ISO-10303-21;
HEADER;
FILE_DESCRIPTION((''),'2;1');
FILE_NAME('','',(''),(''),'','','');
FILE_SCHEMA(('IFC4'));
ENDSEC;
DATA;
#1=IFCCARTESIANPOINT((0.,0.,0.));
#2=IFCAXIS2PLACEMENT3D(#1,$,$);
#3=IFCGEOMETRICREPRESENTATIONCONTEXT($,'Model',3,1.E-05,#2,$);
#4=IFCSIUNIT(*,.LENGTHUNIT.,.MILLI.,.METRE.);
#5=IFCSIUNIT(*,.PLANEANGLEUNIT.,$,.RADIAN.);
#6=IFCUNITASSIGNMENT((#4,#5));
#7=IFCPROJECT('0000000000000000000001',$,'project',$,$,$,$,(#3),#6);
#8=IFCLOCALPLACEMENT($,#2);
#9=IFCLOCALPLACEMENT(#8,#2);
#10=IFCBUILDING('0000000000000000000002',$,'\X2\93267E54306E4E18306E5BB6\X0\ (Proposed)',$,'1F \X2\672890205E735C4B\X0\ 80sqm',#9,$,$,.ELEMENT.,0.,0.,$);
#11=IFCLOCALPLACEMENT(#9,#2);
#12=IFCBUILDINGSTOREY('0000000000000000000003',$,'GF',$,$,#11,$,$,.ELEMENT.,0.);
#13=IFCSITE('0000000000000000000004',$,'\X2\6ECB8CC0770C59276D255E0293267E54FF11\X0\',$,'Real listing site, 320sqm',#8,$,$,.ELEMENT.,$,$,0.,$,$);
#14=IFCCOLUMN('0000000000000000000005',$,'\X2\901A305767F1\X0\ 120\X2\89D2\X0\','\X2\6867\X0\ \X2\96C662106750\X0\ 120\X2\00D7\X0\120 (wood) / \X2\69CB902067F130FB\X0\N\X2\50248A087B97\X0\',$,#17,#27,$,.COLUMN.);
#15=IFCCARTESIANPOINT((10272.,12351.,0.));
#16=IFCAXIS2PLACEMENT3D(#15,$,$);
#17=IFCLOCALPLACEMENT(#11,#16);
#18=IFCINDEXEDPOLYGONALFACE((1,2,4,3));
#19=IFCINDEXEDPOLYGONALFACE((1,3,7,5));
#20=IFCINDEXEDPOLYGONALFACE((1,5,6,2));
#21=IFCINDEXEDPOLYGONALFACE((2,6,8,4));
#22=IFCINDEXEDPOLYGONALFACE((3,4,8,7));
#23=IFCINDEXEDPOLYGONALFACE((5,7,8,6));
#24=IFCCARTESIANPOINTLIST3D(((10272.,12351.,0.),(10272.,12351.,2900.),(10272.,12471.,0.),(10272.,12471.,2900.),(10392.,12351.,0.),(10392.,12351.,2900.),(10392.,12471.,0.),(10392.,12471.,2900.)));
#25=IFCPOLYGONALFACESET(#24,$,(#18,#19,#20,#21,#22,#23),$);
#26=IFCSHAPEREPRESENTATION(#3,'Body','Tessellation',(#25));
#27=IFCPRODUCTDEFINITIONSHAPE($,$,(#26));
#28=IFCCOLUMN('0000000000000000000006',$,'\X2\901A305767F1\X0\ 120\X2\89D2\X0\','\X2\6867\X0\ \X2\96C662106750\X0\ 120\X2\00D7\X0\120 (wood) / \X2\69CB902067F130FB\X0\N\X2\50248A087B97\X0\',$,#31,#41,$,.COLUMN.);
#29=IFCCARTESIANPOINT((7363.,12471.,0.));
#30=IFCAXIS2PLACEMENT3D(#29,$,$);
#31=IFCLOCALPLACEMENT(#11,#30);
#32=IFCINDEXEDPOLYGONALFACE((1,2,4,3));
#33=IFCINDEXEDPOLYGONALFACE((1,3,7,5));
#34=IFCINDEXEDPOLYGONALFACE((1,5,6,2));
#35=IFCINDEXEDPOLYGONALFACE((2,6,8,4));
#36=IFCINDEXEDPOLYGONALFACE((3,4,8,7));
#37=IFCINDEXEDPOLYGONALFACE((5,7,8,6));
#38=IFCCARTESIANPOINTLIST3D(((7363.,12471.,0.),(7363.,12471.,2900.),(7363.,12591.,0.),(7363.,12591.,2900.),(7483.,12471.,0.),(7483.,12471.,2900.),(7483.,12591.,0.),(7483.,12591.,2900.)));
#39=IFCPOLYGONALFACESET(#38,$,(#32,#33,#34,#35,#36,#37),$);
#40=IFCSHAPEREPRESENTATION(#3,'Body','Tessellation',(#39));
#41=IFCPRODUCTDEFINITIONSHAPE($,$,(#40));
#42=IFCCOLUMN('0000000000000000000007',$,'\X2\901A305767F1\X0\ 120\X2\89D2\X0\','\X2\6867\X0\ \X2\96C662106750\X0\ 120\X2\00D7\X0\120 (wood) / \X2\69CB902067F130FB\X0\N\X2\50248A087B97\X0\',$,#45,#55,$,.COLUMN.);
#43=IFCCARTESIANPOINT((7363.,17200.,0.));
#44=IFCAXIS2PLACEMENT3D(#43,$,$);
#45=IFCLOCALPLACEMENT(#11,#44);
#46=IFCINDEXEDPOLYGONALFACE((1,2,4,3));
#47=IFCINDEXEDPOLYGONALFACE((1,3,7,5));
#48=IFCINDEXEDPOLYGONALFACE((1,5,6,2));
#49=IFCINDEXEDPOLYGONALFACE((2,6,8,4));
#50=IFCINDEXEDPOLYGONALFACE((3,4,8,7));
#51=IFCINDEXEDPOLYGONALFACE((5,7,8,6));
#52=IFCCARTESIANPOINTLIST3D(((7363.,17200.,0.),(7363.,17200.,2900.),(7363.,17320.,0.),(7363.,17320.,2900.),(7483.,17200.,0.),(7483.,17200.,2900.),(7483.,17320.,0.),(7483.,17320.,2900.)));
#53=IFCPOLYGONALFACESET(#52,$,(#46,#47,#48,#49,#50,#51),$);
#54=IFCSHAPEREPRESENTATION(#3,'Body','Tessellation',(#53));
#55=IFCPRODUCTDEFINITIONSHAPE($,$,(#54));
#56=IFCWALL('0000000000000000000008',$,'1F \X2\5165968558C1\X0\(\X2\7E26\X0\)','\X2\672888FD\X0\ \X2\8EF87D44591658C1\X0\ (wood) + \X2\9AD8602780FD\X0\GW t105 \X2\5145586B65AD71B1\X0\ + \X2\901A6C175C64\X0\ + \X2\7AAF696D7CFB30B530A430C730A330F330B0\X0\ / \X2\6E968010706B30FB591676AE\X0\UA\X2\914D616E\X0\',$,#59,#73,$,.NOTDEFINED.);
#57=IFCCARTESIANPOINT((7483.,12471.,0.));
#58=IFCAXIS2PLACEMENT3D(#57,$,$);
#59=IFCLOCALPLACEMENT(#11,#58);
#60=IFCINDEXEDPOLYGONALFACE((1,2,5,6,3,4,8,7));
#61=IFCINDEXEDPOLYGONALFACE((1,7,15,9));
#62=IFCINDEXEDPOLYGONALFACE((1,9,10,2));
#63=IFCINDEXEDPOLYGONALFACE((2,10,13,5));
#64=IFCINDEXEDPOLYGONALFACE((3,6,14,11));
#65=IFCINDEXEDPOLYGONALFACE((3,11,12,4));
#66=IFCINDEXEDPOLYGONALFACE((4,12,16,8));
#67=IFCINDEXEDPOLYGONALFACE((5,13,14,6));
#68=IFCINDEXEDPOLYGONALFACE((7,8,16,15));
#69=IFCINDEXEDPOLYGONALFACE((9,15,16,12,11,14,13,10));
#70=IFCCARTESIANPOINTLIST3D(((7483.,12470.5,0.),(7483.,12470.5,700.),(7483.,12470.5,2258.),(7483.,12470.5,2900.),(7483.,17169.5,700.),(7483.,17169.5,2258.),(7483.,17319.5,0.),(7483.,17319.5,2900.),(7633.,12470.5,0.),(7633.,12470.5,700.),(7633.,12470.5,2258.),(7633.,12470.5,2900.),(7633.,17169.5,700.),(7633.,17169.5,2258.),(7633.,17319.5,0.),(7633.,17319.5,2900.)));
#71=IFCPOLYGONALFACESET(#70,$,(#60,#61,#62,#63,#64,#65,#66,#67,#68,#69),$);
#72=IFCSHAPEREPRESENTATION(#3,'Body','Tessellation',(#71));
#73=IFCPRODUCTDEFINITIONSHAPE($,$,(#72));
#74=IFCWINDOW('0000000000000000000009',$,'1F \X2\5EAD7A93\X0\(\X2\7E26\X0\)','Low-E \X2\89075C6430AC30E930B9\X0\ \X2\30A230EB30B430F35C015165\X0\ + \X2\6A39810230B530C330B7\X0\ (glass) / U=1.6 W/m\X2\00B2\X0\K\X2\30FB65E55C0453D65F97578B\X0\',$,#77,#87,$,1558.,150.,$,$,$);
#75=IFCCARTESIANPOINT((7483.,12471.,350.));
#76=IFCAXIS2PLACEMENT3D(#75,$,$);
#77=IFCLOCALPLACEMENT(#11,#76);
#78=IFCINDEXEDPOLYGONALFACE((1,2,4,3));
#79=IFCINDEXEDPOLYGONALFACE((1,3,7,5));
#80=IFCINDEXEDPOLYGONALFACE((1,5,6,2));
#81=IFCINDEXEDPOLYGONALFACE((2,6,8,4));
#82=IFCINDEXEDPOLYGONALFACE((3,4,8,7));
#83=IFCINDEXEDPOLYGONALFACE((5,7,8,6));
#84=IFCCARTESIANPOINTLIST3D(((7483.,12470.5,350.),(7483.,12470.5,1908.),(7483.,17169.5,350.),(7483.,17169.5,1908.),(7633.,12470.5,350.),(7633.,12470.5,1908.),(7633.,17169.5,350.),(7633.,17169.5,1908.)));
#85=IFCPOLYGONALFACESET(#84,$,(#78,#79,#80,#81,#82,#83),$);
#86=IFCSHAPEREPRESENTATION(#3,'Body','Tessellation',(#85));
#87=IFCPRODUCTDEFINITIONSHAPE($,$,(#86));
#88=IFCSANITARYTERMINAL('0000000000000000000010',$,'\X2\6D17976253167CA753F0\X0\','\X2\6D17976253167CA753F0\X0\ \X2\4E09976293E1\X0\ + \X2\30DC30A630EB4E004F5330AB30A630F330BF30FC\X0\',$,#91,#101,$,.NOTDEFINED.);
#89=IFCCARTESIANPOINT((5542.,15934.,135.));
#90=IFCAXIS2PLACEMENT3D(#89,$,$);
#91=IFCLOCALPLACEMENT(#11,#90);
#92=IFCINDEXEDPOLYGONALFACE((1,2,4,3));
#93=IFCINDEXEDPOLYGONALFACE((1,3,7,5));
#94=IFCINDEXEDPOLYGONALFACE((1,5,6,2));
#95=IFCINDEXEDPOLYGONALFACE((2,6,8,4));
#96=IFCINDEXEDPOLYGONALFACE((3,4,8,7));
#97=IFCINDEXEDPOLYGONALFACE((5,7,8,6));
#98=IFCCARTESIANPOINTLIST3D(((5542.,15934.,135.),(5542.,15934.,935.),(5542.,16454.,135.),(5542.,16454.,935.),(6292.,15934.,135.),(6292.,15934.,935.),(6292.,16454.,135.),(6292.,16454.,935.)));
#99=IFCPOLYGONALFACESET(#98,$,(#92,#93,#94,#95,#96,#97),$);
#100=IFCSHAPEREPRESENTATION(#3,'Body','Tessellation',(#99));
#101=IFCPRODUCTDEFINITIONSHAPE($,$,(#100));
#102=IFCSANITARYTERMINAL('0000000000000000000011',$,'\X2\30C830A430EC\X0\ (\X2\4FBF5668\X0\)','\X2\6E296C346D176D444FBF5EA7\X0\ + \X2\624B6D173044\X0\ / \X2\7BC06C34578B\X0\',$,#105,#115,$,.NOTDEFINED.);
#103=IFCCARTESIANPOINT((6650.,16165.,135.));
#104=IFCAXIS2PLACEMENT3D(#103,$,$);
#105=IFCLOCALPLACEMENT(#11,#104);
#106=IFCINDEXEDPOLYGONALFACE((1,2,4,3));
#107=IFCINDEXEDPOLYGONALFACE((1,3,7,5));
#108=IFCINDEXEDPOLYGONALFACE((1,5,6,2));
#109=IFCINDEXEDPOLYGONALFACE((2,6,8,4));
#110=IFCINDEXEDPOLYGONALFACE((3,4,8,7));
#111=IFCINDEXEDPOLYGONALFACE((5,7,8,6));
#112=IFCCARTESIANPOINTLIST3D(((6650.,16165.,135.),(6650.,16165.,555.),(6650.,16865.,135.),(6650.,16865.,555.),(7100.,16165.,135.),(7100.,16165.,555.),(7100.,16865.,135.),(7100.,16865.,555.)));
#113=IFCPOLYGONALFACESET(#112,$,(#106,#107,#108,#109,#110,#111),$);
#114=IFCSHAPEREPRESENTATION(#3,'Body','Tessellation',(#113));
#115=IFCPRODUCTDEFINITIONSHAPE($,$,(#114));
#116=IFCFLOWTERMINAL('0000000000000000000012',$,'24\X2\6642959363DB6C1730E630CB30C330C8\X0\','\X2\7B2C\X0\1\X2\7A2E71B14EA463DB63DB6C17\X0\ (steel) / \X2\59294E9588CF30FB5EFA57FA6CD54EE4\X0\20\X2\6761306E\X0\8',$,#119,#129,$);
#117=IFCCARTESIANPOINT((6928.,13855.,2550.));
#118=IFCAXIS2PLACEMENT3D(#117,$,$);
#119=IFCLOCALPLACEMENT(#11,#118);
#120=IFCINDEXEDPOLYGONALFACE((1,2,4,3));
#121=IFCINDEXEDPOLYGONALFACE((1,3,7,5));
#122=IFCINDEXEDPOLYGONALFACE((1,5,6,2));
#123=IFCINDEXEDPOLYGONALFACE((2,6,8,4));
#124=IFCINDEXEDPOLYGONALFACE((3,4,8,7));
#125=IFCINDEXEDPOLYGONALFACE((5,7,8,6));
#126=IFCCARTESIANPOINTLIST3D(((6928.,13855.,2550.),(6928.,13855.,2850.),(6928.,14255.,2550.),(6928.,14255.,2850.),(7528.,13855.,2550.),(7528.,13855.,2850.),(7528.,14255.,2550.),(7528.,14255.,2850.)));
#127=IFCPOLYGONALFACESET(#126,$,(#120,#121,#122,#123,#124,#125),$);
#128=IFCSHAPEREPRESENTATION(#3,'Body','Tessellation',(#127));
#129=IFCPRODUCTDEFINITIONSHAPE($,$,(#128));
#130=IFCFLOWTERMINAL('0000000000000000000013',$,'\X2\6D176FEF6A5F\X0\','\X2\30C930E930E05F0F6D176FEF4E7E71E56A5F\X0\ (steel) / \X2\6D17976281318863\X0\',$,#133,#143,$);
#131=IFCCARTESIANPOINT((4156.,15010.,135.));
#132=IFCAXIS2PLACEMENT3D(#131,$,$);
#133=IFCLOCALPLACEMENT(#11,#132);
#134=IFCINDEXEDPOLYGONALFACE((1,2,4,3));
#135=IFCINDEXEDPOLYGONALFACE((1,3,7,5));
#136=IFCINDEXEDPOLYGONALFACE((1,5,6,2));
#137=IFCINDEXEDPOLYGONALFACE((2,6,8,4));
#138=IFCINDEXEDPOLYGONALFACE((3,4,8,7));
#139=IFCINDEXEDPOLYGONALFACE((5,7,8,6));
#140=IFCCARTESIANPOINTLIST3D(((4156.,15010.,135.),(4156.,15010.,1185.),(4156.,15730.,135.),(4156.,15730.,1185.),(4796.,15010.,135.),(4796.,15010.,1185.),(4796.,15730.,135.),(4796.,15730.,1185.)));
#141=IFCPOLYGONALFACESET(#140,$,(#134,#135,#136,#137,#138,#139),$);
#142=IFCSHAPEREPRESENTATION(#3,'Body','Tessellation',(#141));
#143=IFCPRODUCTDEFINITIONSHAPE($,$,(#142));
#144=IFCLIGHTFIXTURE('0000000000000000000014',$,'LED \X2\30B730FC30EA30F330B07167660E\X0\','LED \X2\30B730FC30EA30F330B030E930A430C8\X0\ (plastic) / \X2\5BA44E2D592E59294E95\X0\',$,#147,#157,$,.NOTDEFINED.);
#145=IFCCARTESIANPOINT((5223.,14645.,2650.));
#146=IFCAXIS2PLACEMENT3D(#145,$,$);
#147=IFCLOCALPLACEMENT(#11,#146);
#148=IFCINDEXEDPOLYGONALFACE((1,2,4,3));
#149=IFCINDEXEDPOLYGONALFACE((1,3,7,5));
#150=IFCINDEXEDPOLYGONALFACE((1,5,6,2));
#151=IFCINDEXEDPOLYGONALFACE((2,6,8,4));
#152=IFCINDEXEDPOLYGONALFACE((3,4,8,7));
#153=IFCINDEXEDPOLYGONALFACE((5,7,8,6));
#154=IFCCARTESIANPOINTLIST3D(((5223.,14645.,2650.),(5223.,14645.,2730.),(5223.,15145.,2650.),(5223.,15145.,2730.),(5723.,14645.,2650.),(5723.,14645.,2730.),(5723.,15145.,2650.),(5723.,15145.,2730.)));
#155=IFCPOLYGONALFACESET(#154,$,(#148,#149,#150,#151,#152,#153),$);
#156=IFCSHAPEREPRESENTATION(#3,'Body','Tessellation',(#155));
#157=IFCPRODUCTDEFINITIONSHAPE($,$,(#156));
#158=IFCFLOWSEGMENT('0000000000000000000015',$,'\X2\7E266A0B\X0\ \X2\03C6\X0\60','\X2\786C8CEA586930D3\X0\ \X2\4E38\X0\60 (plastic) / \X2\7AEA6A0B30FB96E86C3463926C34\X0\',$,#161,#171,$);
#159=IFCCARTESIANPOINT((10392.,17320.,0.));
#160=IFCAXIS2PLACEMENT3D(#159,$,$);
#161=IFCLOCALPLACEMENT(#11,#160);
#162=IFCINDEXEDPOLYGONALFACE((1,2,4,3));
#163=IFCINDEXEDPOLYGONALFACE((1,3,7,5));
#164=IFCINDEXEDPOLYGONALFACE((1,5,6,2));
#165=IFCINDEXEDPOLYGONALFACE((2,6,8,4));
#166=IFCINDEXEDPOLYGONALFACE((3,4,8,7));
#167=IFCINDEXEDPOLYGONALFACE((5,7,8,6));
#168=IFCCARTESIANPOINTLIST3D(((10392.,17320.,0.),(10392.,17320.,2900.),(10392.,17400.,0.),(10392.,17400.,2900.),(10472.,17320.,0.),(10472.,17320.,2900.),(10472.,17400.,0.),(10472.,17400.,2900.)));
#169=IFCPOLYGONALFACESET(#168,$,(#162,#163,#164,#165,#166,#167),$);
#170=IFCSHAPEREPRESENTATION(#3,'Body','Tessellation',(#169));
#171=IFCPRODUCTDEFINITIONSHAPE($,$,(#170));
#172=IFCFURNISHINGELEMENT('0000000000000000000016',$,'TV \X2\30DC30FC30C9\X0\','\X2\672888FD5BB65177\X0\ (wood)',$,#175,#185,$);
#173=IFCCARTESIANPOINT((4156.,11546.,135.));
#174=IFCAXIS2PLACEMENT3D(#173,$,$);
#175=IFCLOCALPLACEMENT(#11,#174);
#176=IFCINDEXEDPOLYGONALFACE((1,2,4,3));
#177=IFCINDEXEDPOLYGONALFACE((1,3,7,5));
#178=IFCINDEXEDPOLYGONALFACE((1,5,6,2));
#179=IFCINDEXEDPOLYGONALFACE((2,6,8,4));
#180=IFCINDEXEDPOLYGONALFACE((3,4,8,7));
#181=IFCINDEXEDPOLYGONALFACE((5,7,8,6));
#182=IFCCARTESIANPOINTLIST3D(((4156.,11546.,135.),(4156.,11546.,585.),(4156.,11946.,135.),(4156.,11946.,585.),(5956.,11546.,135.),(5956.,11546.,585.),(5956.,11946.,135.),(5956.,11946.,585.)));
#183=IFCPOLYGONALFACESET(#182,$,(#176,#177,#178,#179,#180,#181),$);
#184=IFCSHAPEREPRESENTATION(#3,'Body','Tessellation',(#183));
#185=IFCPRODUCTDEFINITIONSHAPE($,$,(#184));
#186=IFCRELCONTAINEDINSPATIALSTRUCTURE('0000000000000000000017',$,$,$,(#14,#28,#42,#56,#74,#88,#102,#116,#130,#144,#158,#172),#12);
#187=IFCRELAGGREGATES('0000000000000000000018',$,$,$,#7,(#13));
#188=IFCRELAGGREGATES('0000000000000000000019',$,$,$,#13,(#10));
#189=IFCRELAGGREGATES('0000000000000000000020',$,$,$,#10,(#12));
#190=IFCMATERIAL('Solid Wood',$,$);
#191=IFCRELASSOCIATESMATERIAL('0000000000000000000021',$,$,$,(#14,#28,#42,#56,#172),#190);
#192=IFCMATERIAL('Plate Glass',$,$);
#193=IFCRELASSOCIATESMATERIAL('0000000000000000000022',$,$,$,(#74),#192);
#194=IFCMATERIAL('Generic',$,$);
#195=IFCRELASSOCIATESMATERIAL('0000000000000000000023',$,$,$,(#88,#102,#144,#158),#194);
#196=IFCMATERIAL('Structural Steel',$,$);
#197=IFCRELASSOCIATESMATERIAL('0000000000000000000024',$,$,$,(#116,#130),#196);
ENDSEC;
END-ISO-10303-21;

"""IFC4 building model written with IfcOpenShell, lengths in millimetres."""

from ifc_helpers import new_model, si_unit, frame, frame_2d, origin, place, context, project, spatial, rectangle, extrude, material, element, fill, save


model = new_model("IFC4")

# Units and contexts
model_context = context("Model", 3, precision=1e-05, world=origin())
ifc_project = project(units=[si_unit("LENGTHUNIT", "METRE", prefix="MILLI"), si_unit("PLANEANGLEUNIT", "RADIAN")], contexts=[model_context])

# Site, building, storey
site_placement = place(None, origin())
site = spatial("IfcSite", under=ifc_project, at=site_placement, Name="滋賀県大津市錦織１", ObjectType="Real listing site, 320sqm", CompositionType="ELEMENT", RefElevation=0.0)
building_placement = place(site_placement, origin())
building = spatial("IfcBuilding", under=site, at=building_placement, Name="錦織の丘の家 (Proposed)", ObjectType="1F 木造平屋 80sqm", CompositionType="ELEMENT", ElevationOfRefHeight=0.0, ElevationOfTerrain=0.0)
storey_placement = place(building_placement, origin())
storey = spatial("IfcBuildingStorey", under=building, at=storey_placement, Name="GF", CompositionType="ELEMENT", Elevation=0.0)

# Columns
ifc_material_1 = material(Name="Solid Wood")
column_1_placement = place(storey_placement, frame((10272.0, 12351.0, 0.0)))
element("IfcColumn", 1, at=column_1_placement, inside=storey, material=ifc_material_1, Name="通し柱 120角", Description="桧 集成材 120×120 (wood) / 構造柱・N値計算", PredefinedType="COLUMN", context=model_context, shape_type="SweptSolid", body=[
    extrude(rectangle(XDim=120.0, YDim=120.0, at=frame_2d((60.0, 60.0))), frame((10272.0, 12351.0, 0.0)), (0.0, 0.0, 1.0), 2900.0),
])
column_2_placement = place(storey_placement, frame((7363.0, 12471.0, 0.0)))
element("IfcColumn", 2, at=column_2_placement, inside=storey, material=ifc_material_1, Name="通し柱 120角", Description="桧 集成材 120×120 (wood) / 構造柱・N値計算", PredefinedType="COLUMN", context=model_context, shape_type="SweptSolid", body=[
    extrude(rectangle(XDim=120.0, YDim=120.0, at=frame_2d((60.0, 60.0))), frame((7363.0, 12471.0, 0.0)), (0.0, 0.0, 1.0), 2900.0),
])
column_3_placement = place(storey_placement, frame((7363.0, 17200.0, 0.0)))
element("IfcColumn", 3, at=column_3_placement, inside=storey, material=ifc_material_1, Name="通し柱 120角", Description="桧 集成材 120×120 (wood) / 構造柱・N値計算", PredefinedType="COLUMN", context=model_context, shape_type="SweptSolid", body=[
    extrude(rectangle(XDim=120.0, YDim=120.0, at=frame_2d((60.0, 60.0))), frame((7363.0, 17200.0, 0.0)), (0.0, 0.0, 1.0), 2900.0),
])

# Wall, opening, window
wall_1_placement = place(storey_placement, frame((7483.0, 12471.0, 0.0)))
wall_1 = element("IfcWall", 4, at=wall_1_placement, inside=storey, material=ifc_material_1, Name="1F 入隅壁(縦)", Description="木製 軸組外壁 (wood) + 高性能GW t105 充填断熱 + 通気層 + 窯業系サイディング / 準耐火・外皮UA配慮", PredefinedType="NOTDEFINED", context=model_context, shape_type="SweptSolid", body=[
    extrude(rectangle(XDim=150.0, YDim=4849.0, at=frame_2d((75.0, 2424.0))), frame((7483.0, 12471.0, 0.0)), (0.0, 0.0, 1.0), 2900.0),
])
opening_placement = place(storey_placement, frame((7483.0, 12471.0, 350.0)))
opening = element("IfcOpeningElement", 5, at=opening_placement, cuts=wall_1, PredefinedType="NOTDEFINED", context=model_context, shape_type="SweptSolid", body=[
    extrude(rectangle(XDim=150.0, YDim=4699.0, at=frame_2d((75.0, 2349.0))), frame((7483.0, 12471.0, 350.0)), (0.0, 0.0, 1.0), 1558.0),
])
ifc_material_2 = material(Name="Plate Glass")
window_placement = place(storey_placement, frame((7483.0, 12471.0, 350.0)))
window = element("IfcWindow", 6, at=window_placement, inside=storey, material=ifc_material_2, Name="1F 庭窓(縦)", Description="Low-E 複層ガラス アルゴン封入 + 樹脂サッシ (glass) / U=1.6 W/m²K・日射取得型", OverallHeight=1558.0, OverallWidth=150.0, context=model_context, shape_type="SweptSolid", body=[
    extrude(rectangle(XDim=150.0, YDim=4699.0, at=frame_2d((75.0, 2349.0))), frame((7483.0, 12471.0, 350.0)), (0.0, 0.0, 1.0), 1558.0),
])
fill(opening, window)

# Sanitary terminals
ifc_material_3 = material(Name="Generic")
sanitary_terminal_1_placement = place(storey_placement, frame((5542.0, 15934.0, 135.0)))
element("IfcSanitaryTerminal", 7, at=sanitary_terminal_1_placement, inside=storey, material=ifc_material_3, Name="洗面化粧台", Description="洗面化粧台 三面鏡 + ボウル一体カウンター", PredefinedType="NOTDEFINED", context=model_context, shape_type="SweptSolid", body=[
    extrude(rectangle(XDim=750.0, YDim=520.0, at=frame_2d((375.0, 260.0))), frame((5542.0, 15934.0, 135.0)), (0.0, 0.0, 1.0), 800.0),
])
sanitary_terminal_2_placement = place(storey_placement, frame((6650.0, 16165.0, 135.0)))
element("IfcSanitaryTerminal", 8, at=sanitary_terminal_2_placement, inside=storey, material=ifc_material_3, Name="トイレ (便器)", Description="温水洗浄便座 + 手洗い / 節水型", PredefinedType="NOTDEFINED", context=model_context, shape_type="SweptSolid", body=[
    extrude(rectangle(XDim=450.0, YDim=700.0, at=frame_2d((225.0, 350.0))), frame((6650.0, 16165.0, 135.0)), (0.0, 0.0, 1.0), 420.0),
])

# Flow terminals
ifc_material_4 = material(Name="Structural Steel")
flow_terminal_1_placement = place(storey_placement, frame((6928.0, 13855.0, 2550.0)))
element("IfcFlowTerminal", 9, at=flow_terminal_1_placement, inside=storey, material=ifc_material_4, Name="24時間換気ユニット", Description="第1種熱交換換気 (steel) / 天井裏・建基法令20条の8", context=model_context, shape_type="SweptSolid", body=[
    extrude(rectangle(XDim=600.0, YDim=400.0, at=frame_2d((300.0, 200.0))), frame((6928.0, 13855.0, 2550.0)), (0.0, 0.0, 1.0), 300.0),
])
flow_terminal_2_placement = place(storey_placement, frame((4156.0, 15010.0, 135.0)))
element("IfcFlowTerminal", 10, at=flow_terminal_2_placement, inside=storey, material=ifc_material_4, Name="洗濯機", Description="ドラム式洗濯乾燥機 (steel) / 洗面脱衣", context=model_context, shape_type="SweptSolid", body=[
    extrude(rectangle(XDim=640.0, YDim=720.0, at=frame_2d((320.0, 360.0))), frame((4156.0, 15010.0, 135.0)), (0.0, 0.0, 1.0), 1050.0),
])

# Light fixture
light_fixture_placement = place(storey_placement, frame((5223.0, 14645.0, 2650.0)))
element("IfcLightFixture", 11, at=light_fixture_placement, inside=storey, material=ifc_material_3, Name="LED シーリング照明", Description="LED シーリングライト (plastic) / 室中央天井", PredefinedType="NOTDEFINED", context=model_context, shape_type="SweptSolid", body=[
    extrude(rectangle(XDim=500.0, YDim=500.0, at=frame_2d((250.0, 250.0))), frame((5223.0, 14645.0, 2650.0)), (0.0, 0.0, 1.0), 80.0),
])

# Flow segment
flow_segment_placement = place(storey_placement, frame((10392.0, 17320.0, 0.0)))
element("IfcFlowSegment", 12, at=flow_segment_placement, inside=storey, material=ifc_material_3, Name="縦樋 φ60", Description="硬質塩ビ 丸60 (plastic) / 竪樋・雨水排水", context=model_context, shape_type="SweptSolid", body=[
    extrude(rectangle(XDim=80.0, YDim=80.0, at=frame_2d((40.0, 40.0))), frame((10392.0, 17320.0, 0.0)), (0.0, 0.0, 1.0), 2900.0),
])

# Furnishing element
furnishing_placement = place(storey_placement, frame((4156.0, 11546.0, 135.0)))
element("IfcFurnishingElement", 13, at=furnishing_placement, inside=storey, material=ifc_material_1, Name="TV ボード", Description="木製家具 (wood)", context=model_context, shape_type="SweptSolid", body=[
    extrude(rectangle(XDim=1800.0, YDim=400.0, at=frame_2d((900.0, 200.0))), frame((4156.0, 11546.0, 135.0)), (0.0, 0.0, 1.0), 450.0),
])

save(model, "model.ifc")
